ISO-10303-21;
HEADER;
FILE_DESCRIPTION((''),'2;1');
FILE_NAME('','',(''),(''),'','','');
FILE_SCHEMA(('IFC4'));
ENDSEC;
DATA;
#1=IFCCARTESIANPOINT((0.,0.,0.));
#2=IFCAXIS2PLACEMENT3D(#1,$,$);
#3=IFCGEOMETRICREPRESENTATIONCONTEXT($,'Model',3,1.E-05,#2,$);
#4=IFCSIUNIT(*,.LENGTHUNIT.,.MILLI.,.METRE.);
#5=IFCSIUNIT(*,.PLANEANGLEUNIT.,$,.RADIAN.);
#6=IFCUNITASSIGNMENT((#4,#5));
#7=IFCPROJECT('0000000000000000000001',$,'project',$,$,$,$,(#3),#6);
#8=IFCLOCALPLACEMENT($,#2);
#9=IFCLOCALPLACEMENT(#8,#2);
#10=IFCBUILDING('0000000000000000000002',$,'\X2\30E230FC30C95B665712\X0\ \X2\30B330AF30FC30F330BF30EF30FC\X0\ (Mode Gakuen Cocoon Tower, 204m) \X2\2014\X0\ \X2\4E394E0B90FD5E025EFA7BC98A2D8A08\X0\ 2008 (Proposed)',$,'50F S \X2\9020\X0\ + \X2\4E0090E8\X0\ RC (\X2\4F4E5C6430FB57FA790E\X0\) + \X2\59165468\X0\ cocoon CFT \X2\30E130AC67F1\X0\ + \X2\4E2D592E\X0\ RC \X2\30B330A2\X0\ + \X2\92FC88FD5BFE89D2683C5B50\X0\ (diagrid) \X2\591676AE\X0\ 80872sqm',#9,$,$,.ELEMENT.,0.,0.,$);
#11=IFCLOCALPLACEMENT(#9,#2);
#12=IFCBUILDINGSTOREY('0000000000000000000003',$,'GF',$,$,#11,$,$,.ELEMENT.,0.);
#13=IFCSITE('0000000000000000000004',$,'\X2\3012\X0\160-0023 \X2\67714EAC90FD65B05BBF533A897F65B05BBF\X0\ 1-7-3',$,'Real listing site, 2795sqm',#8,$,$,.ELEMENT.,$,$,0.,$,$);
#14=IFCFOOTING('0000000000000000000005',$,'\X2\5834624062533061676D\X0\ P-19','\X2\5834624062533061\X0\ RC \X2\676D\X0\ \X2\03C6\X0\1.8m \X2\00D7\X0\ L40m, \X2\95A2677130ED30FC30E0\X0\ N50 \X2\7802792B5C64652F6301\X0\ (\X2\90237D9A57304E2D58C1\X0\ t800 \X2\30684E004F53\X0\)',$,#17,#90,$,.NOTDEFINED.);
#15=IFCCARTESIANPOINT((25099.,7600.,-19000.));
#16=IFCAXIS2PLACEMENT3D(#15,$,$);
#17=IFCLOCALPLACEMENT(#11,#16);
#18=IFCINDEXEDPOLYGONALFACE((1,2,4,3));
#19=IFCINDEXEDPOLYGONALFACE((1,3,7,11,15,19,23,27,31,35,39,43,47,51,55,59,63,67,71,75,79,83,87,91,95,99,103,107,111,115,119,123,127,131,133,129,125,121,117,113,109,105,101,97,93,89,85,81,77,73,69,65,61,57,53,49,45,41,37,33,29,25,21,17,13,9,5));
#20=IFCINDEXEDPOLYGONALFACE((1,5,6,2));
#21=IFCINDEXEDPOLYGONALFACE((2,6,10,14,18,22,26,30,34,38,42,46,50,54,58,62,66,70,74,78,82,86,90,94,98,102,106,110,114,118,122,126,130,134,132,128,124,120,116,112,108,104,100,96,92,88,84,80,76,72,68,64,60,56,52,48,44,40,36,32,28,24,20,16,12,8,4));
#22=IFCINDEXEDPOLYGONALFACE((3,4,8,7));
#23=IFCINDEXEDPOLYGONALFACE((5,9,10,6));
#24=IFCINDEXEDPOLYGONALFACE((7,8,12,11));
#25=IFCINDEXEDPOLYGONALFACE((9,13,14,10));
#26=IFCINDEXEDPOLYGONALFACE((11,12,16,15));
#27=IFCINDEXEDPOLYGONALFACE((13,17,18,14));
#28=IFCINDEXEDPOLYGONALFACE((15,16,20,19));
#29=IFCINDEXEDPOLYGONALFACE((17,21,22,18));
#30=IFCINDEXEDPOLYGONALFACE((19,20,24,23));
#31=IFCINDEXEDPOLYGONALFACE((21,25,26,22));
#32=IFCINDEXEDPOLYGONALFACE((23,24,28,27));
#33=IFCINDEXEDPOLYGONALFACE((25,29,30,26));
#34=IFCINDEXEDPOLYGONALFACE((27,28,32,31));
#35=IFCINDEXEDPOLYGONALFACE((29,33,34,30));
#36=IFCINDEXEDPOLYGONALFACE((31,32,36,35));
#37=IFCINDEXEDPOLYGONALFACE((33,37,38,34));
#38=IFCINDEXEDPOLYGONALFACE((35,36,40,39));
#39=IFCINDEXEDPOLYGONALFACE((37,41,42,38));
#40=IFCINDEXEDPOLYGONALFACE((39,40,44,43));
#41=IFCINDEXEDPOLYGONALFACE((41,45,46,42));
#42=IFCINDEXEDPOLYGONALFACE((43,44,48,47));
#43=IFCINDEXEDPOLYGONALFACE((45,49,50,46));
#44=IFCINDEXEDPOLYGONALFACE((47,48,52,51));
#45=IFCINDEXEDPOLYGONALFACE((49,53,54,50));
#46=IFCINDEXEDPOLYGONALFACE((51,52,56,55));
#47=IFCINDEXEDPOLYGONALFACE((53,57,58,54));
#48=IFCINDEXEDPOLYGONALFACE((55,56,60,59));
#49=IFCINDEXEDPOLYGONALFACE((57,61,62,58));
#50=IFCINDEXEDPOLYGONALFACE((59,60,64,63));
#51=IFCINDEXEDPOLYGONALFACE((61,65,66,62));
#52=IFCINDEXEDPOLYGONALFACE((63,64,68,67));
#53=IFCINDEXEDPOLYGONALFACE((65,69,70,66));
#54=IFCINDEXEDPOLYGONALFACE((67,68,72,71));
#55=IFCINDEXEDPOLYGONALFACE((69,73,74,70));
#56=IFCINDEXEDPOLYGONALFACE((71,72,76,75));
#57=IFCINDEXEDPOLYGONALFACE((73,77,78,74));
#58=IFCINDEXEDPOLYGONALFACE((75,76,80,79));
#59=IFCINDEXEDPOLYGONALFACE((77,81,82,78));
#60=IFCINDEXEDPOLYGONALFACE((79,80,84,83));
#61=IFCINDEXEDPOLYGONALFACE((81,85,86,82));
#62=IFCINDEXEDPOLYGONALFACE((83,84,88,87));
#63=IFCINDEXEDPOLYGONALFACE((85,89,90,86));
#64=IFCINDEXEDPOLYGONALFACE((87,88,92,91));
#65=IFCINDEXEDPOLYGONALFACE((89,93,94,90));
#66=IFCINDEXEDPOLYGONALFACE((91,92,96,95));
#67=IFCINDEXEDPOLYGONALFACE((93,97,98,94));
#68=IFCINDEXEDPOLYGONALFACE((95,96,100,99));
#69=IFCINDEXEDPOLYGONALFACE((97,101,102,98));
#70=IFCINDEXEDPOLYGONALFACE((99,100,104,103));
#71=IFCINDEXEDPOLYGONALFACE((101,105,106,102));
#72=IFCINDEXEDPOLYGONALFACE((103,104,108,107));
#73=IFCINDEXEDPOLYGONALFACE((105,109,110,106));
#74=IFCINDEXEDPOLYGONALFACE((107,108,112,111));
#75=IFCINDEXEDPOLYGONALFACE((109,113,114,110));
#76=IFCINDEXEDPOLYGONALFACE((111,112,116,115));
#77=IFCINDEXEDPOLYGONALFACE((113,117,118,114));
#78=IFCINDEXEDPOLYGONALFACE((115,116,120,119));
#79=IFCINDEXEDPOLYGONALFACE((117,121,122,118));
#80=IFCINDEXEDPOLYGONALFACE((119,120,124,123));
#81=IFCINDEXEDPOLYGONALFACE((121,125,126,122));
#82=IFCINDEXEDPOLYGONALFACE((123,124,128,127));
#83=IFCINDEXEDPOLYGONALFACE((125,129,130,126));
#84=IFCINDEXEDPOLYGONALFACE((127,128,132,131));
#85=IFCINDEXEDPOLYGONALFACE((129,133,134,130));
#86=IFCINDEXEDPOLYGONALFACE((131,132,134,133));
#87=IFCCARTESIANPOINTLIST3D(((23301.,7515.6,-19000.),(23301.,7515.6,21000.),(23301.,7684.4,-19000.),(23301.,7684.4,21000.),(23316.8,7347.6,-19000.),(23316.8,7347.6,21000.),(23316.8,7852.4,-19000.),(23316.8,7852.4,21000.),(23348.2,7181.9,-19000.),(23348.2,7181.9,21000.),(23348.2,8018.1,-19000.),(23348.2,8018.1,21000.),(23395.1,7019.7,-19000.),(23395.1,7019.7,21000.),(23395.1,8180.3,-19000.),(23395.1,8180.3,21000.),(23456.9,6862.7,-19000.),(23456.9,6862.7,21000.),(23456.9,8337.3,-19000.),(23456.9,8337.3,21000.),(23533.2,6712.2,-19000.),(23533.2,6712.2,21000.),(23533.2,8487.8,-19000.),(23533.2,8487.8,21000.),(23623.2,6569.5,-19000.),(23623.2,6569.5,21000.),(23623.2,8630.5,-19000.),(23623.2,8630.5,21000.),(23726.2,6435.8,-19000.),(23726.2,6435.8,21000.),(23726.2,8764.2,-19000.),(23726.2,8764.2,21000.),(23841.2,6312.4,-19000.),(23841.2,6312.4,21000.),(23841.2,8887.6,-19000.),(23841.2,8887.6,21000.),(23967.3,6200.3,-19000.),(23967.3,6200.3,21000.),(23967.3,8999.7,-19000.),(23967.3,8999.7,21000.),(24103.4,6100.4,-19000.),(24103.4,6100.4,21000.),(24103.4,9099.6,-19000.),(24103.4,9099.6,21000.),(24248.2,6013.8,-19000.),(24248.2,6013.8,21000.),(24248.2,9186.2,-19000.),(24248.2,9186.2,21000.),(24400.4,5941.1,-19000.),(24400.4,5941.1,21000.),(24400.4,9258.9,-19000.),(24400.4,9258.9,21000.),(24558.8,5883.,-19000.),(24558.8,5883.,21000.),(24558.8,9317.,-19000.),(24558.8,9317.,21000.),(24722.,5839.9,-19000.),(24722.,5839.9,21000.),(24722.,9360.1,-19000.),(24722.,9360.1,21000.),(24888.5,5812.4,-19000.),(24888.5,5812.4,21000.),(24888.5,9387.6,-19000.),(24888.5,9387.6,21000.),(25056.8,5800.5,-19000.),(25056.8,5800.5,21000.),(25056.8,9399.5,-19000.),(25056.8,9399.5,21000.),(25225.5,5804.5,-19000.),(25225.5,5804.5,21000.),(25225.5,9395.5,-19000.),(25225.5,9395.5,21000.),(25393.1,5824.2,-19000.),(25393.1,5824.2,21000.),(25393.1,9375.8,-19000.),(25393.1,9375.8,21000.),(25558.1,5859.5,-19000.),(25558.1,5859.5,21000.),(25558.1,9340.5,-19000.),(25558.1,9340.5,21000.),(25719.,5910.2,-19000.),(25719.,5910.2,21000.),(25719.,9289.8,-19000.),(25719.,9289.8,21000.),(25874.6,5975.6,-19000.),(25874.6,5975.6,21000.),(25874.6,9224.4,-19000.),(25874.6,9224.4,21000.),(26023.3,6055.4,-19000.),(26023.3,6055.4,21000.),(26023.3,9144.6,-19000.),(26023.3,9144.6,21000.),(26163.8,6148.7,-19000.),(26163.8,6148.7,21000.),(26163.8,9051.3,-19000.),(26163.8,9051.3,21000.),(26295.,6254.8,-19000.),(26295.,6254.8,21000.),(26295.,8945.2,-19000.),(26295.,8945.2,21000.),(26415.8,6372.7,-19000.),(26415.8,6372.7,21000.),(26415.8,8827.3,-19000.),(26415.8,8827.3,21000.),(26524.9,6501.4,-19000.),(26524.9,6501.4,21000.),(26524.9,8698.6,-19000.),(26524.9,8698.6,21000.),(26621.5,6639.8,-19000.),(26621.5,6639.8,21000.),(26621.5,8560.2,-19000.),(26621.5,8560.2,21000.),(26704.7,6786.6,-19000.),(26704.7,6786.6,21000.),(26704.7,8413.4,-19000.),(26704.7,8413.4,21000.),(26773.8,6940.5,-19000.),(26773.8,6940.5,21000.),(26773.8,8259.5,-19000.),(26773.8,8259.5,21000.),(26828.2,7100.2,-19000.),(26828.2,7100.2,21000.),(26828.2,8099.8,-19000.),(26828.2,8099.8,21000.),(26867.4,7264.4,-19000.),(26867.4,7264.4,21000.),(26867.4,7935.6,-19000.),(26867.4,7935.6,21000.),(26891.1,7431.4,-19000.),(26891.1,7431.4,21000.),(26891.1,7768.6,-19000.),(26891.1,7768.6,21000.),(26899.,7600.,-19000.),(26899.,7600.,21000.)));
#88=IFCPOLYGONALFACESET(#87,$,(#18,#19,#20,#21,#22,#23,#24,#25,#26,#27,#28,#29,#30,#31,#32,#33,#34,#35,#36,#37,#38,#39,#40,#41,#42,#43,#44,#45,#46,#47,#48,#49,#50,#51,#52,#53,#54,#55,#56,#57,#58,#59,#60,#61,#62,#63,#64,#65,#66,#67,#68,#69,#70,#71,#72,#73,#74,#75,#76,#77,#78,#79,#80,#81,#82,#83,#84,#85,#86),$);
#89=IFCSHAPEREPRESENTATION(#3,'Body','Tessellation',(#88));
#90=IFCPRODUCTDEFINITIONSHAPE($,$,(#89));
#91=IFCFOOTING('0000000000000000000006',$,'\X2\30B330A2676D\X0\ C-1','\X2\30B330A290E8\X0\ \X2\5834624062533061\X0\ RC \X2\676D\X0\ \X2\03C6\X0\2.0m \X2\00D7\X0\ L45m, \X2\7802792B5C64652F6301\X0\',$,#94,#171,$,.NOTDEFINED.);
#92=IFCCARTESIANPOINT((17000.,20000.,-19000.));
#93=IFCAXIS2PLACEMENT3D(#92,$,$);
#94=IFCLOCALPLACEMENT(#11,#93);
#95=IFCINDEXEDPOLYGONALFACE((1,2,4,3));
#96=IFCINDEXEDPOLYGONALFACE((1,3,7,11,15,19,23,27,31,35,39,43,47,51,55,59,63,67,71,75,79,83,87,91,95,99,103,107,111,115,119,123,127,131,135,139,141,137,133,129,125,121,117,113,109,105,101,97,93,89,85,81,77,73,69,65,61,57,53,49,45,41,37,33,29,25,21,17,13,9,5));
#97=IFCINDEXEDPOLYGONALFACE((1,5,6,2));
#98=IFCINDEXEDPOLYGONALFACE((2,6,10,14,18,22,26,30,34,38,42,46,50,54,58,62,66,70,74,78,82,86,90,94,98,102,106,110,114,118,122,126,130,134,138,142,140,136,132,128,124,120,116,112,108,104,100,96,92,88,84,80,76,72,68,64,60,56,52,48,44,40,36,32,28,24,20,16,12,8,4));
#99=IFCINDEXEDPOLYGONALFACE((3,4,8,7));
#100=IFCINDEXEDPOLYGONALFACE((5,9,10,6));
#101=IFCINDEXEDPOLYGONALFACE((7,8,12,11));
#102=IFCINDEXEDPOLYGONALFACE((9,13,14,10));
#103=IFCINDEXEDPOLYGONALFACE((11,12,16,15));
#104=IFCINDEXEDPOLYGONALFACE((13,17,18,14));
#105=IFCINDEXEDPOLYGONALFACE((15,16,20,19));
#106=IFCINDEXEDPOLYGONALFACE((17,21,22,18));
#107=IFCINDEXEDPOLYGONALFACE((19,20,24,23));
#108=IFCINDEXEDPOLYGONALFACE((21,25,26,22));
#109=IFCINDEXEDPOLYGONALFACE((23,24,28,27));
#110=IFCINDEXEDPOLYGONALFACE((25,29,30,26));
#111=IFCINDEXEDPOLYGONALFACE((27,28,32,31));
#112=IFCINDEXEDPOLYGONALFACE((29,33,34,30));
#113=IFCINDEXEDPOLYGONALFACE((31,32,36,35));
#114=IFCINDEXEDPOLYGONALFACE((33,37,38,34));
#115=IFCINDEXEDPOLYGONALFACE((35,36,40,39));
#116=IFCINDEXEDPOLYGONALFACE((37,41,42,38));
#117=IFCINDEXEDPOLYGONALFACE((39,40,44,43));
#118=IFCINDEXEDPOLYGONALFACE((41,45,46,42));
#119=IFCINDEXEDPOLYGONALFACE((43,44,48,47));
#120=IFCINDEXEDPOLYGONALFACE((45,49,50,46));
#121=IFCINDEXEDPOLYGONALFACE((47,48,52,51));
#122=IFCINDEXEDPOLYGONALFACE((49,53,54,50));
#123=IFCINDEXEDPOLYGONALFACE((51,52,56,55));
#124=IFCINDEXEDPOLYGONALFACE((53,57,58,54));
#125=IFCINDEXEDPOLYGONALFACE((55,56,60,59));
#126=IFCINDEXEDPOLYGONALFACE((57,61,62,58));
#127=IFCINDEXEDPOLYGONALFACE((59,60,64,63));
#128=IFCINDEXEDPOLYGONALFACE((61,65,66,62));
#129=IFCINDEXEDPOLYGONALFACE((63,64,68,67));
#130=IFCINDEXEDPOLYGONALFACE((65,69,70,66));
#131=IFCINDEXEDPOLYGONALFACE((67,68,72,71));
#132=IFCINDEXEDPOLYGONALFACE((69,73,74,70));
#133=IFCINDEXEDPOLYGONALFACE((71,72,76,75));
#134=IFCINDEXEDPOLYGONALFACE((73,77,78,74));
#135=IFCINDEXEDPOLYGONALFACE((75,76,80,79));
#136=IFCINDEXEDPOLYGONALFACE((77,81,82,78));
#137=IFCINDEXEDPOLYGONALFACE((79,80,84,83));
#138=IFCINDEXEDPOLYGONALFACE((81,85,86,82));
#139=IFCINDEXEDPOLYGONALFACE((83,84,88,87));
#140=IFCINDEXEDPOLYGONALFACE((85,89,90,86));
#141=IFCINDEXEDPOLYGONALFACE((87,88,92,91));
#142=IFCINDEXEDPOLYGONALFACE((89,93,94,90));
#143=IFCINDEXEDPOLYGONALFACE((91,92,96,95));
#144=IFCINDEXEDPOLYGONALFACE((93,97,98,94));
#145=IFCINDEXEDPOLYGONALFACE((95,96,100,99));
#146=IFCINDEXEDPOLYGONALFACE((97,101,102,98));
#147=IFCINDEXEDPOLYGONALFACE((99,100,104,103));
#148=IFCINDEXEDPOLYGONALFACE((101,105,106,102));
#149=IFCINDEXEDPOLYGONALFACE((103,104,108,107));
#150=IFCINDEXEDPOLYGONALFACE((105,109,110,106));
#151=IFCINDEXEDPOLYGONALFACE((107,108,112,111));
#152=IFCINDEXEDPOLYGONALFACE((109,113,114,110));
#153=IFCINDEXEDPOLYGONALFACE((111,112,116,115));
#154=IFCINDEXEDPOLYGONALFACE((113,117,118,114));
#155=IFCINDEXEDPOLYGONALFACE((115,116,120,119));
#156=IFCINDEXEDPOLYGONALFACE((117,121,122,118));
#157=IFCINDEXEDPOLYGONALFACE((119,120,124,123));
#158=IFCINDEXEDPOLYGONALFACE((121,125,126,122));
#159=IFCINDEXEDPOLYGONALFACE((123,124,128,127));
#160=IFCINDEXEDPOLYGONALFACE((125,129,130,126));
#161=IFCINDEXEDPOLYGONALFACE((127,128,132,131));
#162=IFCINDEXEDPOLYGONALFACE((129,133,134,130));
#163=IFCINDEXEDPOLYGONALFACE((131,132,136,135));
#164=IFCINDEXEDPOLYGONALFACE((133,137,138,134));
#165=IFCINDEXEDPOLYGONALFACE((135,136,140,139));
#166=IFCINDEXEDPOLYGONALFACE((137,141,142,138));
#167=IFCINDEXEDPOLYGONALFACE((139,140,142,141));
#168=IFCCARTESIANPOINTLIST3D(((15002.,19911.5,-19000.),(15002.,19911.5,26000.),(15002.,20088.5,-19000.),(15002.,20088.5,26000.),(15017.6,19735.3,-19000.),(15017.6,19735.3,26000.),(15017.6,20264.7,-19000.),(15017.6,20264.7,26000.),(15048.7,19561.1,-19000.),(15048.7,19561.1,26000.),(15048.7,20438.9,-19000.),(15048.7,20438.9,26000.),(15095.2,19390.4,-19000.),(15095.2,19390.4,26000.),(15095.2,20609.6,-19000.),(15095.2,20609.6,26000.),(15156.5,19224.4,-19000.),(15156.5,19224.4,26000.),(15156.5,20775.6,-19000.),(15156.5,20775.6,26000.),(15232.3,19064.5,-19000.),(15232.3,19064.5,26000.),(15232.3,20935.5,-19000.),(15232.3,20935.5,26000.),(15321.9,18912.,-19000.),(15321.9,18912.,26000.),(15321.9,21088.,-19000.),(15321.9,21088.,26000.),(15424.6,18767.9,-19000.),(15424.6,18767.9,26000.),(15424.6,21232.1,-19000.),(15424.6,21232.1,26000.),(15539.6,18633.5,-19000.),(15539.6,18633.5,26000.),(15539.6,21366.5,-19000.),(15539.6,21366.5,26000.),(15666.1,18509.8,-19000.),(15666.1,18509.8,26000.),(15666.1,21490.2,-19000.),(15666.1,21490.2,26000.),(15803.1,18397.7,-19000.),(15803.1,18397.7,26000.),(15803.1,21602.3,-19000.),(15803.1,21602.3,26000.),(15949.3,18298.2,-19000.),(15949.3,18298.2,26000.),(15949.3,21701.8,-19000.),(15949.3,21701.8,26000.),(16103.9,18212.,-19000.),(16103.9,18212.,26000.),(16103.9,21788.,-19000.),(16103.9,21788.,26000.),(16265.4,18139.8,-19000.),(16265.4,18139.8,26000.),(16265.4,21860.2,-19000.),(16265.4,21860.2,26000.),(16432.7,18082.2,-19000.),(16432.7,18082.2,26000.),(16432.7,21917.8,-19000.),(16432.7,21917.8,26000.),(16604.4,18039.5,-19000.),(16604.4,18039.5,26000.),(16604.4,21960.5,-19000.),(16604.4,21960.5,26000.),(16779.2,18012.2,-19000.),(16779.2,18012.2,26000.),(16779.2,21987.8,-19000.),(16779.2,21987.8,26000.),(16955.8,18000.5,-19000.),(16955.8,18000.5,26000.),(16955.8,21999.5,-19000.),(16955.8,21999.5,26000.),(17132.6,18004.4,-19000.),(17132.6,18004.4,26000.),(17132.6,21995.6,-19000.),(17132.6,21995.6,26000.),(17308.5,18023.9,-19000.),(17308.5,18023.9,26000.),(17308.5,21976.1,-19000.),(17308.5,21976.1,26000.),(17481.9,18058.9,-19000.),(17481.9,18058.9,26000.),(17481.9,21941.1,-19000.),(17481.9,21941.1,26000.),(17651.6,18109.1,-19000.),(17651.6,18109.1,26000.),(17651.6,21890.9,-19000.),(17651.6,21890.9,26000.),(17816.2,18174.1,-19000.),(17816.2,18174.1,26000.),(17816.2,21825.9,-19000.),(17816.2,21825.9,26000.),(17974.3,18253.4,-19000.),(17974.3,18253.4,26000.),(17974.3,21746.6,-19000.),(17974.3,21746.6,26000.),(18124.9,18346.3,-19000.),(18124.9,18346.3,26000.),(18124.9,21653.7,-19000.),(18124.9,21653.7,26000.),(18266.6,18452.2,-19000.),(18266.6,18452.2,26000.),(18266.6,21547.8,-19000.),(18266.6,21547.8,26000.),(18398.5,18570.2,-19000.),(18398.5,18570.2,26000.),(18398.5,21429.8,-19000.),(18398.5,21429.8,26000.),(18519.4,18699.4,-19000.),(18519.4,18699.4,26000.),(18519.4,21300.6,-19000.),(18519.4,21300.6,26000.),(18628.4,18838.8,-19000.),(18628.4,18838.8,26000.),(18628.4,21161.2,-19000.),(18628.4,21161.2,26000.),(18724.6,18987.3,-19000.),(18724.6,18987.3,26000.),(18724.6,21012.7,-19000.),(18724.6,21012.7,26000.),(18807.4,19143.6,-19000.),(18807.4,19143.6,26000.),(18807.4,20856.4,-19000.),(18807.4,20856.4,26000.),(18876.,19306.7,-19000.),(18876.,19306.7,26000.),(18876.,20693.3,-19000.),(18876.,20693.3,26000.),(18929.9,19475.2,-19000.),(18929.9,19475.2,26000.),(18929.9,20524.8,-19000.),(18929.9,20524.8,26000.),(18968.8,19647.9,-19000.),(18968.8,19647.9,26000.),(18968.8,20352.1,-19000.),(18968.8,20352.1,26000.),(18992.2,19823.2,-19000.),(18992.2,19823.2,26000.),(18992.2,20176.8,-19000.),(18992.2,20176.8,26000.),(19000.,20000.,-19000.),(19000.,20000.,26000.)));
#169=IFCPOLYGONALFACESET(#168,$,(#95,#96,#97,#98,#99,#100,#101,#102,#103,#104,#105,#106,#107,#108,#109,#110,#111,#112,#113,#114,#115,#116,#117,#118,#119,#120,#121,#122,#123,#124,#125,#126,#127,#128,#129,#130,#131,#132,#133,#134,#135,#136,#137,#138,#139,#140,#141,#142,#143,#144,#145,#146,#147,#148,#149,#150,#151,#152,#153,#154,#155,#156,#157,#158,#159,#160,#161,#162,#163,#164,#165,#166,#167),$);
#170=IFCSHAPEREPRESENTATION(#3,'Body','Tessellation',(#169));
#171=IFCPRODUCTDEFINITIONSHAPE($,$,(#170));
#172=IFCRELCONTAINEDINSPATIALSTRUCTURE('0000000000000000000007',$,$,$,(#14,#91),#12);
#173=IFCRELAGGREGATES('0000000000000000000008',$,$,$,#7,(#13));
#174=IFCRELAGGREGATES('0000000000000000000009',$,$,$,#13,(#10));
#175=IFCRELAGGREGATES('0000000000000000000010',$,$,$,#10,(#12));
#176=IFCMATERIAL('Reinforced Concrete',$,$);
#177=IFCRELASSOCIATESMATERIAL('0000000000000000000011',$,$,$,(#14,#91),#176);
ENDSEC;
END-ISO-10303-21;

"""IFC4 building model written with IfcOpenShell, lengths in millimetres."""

from ifc_helpers import new_model, si_unit, frame, origin, origin_2d, place, context, project, spatial, circle, extrude, material, element, save


model = new_model("IFC4")

# Units and contexts
model_context = context("Model", 3, precision=1e-05, world=origin())
ifc_project = project(units=[si_unit("LENGTHUNIT", "METRE", prefix="MILLI"), si_unit("PLANEANGLEUNIT", "RADIAN")], contexts=[model_context])

# Site, building, storey
site_placement = place(None, origin())
site = spatial("IfcSite", under=ifc_project, at=site_placement, Name="〒160-0023 東京都新宿区西新宿 1-7-3", ObjectType="Real listing site, 2795sqm", CompositionType="ELEMENT", RefElevation=0.0)
building_placement = place(site_placement, origin())
building = spatial("IfcBuilding", under=site, at=building_placement, Name="モード学園 コクーンタワー (Mode Gakuen Cocoon Tower, 204m) — 丹下都市建築設計 2008 (Proposed)", ObjectType="50F S 造 + 一部 RC (低層・基礎) + 外周 cocoon CFT メガ柱 + 中央 RC コア + 鋼製対角格子 (diagrid) 外皮 80872sqm", CompositionType="ELEMENT", ElevationOfRefHeight=0.0, ElevationOfTerrain=0.0)
storey_placement = place(building_placement, origin())
storey = spatial("IfcBuildingStorey", under=building, at=storey_placement, Name="GF", CompositionType="ELEMENT", Elevation=0.0)

# Footings
ifc_material_1 = material(Name="Reinforced Concrete")
footing_1_placement = place(storey_placement, frame((25099.0, 7600.0, -19000.0)))
element("IfcFooting", 1, at=footing_1_placement, inside=storey, material=ifc_material_1, Name="場所打ち杭 P-19", Description="場所打ち RC 杭 φ1.8m × L40m, 関東ローム N50 砂礫層支持 (連続地中壁 t800 と一体)", PredefinedType="NOTDEFINED", context=model_context, shape_type="SweptSolid", body=[
    extrude(circle(Radius=1800.0, at=origin_2d()), frame((25099.0, 7600.0, -19000.0)), (0.0, 0.0, 1.0), 40000.0),
])
footing_2_placement = place(storey_placement, frame((17000.0, 20000.0, -19000.0)))
element("IfcFooting", 2, at=footing_2_placement, inside=storey, material=ifc_material_1, Name="コア杭 C-1", Description="コア部 場所打ち RC 杭 φ2.0m × L45m, 砂礫層支持", PredefinedType="NOTDEFINED", context=model_context, shape_type="SweptSolid", body=[
    extrude(circle(Radius=2000.0, at=origin_2d()), frame((17000.0, 20000.0, -19000.0)), (0.0, 0.0, 1.0), 45000.0),
])

save(model, "model.ifc")
